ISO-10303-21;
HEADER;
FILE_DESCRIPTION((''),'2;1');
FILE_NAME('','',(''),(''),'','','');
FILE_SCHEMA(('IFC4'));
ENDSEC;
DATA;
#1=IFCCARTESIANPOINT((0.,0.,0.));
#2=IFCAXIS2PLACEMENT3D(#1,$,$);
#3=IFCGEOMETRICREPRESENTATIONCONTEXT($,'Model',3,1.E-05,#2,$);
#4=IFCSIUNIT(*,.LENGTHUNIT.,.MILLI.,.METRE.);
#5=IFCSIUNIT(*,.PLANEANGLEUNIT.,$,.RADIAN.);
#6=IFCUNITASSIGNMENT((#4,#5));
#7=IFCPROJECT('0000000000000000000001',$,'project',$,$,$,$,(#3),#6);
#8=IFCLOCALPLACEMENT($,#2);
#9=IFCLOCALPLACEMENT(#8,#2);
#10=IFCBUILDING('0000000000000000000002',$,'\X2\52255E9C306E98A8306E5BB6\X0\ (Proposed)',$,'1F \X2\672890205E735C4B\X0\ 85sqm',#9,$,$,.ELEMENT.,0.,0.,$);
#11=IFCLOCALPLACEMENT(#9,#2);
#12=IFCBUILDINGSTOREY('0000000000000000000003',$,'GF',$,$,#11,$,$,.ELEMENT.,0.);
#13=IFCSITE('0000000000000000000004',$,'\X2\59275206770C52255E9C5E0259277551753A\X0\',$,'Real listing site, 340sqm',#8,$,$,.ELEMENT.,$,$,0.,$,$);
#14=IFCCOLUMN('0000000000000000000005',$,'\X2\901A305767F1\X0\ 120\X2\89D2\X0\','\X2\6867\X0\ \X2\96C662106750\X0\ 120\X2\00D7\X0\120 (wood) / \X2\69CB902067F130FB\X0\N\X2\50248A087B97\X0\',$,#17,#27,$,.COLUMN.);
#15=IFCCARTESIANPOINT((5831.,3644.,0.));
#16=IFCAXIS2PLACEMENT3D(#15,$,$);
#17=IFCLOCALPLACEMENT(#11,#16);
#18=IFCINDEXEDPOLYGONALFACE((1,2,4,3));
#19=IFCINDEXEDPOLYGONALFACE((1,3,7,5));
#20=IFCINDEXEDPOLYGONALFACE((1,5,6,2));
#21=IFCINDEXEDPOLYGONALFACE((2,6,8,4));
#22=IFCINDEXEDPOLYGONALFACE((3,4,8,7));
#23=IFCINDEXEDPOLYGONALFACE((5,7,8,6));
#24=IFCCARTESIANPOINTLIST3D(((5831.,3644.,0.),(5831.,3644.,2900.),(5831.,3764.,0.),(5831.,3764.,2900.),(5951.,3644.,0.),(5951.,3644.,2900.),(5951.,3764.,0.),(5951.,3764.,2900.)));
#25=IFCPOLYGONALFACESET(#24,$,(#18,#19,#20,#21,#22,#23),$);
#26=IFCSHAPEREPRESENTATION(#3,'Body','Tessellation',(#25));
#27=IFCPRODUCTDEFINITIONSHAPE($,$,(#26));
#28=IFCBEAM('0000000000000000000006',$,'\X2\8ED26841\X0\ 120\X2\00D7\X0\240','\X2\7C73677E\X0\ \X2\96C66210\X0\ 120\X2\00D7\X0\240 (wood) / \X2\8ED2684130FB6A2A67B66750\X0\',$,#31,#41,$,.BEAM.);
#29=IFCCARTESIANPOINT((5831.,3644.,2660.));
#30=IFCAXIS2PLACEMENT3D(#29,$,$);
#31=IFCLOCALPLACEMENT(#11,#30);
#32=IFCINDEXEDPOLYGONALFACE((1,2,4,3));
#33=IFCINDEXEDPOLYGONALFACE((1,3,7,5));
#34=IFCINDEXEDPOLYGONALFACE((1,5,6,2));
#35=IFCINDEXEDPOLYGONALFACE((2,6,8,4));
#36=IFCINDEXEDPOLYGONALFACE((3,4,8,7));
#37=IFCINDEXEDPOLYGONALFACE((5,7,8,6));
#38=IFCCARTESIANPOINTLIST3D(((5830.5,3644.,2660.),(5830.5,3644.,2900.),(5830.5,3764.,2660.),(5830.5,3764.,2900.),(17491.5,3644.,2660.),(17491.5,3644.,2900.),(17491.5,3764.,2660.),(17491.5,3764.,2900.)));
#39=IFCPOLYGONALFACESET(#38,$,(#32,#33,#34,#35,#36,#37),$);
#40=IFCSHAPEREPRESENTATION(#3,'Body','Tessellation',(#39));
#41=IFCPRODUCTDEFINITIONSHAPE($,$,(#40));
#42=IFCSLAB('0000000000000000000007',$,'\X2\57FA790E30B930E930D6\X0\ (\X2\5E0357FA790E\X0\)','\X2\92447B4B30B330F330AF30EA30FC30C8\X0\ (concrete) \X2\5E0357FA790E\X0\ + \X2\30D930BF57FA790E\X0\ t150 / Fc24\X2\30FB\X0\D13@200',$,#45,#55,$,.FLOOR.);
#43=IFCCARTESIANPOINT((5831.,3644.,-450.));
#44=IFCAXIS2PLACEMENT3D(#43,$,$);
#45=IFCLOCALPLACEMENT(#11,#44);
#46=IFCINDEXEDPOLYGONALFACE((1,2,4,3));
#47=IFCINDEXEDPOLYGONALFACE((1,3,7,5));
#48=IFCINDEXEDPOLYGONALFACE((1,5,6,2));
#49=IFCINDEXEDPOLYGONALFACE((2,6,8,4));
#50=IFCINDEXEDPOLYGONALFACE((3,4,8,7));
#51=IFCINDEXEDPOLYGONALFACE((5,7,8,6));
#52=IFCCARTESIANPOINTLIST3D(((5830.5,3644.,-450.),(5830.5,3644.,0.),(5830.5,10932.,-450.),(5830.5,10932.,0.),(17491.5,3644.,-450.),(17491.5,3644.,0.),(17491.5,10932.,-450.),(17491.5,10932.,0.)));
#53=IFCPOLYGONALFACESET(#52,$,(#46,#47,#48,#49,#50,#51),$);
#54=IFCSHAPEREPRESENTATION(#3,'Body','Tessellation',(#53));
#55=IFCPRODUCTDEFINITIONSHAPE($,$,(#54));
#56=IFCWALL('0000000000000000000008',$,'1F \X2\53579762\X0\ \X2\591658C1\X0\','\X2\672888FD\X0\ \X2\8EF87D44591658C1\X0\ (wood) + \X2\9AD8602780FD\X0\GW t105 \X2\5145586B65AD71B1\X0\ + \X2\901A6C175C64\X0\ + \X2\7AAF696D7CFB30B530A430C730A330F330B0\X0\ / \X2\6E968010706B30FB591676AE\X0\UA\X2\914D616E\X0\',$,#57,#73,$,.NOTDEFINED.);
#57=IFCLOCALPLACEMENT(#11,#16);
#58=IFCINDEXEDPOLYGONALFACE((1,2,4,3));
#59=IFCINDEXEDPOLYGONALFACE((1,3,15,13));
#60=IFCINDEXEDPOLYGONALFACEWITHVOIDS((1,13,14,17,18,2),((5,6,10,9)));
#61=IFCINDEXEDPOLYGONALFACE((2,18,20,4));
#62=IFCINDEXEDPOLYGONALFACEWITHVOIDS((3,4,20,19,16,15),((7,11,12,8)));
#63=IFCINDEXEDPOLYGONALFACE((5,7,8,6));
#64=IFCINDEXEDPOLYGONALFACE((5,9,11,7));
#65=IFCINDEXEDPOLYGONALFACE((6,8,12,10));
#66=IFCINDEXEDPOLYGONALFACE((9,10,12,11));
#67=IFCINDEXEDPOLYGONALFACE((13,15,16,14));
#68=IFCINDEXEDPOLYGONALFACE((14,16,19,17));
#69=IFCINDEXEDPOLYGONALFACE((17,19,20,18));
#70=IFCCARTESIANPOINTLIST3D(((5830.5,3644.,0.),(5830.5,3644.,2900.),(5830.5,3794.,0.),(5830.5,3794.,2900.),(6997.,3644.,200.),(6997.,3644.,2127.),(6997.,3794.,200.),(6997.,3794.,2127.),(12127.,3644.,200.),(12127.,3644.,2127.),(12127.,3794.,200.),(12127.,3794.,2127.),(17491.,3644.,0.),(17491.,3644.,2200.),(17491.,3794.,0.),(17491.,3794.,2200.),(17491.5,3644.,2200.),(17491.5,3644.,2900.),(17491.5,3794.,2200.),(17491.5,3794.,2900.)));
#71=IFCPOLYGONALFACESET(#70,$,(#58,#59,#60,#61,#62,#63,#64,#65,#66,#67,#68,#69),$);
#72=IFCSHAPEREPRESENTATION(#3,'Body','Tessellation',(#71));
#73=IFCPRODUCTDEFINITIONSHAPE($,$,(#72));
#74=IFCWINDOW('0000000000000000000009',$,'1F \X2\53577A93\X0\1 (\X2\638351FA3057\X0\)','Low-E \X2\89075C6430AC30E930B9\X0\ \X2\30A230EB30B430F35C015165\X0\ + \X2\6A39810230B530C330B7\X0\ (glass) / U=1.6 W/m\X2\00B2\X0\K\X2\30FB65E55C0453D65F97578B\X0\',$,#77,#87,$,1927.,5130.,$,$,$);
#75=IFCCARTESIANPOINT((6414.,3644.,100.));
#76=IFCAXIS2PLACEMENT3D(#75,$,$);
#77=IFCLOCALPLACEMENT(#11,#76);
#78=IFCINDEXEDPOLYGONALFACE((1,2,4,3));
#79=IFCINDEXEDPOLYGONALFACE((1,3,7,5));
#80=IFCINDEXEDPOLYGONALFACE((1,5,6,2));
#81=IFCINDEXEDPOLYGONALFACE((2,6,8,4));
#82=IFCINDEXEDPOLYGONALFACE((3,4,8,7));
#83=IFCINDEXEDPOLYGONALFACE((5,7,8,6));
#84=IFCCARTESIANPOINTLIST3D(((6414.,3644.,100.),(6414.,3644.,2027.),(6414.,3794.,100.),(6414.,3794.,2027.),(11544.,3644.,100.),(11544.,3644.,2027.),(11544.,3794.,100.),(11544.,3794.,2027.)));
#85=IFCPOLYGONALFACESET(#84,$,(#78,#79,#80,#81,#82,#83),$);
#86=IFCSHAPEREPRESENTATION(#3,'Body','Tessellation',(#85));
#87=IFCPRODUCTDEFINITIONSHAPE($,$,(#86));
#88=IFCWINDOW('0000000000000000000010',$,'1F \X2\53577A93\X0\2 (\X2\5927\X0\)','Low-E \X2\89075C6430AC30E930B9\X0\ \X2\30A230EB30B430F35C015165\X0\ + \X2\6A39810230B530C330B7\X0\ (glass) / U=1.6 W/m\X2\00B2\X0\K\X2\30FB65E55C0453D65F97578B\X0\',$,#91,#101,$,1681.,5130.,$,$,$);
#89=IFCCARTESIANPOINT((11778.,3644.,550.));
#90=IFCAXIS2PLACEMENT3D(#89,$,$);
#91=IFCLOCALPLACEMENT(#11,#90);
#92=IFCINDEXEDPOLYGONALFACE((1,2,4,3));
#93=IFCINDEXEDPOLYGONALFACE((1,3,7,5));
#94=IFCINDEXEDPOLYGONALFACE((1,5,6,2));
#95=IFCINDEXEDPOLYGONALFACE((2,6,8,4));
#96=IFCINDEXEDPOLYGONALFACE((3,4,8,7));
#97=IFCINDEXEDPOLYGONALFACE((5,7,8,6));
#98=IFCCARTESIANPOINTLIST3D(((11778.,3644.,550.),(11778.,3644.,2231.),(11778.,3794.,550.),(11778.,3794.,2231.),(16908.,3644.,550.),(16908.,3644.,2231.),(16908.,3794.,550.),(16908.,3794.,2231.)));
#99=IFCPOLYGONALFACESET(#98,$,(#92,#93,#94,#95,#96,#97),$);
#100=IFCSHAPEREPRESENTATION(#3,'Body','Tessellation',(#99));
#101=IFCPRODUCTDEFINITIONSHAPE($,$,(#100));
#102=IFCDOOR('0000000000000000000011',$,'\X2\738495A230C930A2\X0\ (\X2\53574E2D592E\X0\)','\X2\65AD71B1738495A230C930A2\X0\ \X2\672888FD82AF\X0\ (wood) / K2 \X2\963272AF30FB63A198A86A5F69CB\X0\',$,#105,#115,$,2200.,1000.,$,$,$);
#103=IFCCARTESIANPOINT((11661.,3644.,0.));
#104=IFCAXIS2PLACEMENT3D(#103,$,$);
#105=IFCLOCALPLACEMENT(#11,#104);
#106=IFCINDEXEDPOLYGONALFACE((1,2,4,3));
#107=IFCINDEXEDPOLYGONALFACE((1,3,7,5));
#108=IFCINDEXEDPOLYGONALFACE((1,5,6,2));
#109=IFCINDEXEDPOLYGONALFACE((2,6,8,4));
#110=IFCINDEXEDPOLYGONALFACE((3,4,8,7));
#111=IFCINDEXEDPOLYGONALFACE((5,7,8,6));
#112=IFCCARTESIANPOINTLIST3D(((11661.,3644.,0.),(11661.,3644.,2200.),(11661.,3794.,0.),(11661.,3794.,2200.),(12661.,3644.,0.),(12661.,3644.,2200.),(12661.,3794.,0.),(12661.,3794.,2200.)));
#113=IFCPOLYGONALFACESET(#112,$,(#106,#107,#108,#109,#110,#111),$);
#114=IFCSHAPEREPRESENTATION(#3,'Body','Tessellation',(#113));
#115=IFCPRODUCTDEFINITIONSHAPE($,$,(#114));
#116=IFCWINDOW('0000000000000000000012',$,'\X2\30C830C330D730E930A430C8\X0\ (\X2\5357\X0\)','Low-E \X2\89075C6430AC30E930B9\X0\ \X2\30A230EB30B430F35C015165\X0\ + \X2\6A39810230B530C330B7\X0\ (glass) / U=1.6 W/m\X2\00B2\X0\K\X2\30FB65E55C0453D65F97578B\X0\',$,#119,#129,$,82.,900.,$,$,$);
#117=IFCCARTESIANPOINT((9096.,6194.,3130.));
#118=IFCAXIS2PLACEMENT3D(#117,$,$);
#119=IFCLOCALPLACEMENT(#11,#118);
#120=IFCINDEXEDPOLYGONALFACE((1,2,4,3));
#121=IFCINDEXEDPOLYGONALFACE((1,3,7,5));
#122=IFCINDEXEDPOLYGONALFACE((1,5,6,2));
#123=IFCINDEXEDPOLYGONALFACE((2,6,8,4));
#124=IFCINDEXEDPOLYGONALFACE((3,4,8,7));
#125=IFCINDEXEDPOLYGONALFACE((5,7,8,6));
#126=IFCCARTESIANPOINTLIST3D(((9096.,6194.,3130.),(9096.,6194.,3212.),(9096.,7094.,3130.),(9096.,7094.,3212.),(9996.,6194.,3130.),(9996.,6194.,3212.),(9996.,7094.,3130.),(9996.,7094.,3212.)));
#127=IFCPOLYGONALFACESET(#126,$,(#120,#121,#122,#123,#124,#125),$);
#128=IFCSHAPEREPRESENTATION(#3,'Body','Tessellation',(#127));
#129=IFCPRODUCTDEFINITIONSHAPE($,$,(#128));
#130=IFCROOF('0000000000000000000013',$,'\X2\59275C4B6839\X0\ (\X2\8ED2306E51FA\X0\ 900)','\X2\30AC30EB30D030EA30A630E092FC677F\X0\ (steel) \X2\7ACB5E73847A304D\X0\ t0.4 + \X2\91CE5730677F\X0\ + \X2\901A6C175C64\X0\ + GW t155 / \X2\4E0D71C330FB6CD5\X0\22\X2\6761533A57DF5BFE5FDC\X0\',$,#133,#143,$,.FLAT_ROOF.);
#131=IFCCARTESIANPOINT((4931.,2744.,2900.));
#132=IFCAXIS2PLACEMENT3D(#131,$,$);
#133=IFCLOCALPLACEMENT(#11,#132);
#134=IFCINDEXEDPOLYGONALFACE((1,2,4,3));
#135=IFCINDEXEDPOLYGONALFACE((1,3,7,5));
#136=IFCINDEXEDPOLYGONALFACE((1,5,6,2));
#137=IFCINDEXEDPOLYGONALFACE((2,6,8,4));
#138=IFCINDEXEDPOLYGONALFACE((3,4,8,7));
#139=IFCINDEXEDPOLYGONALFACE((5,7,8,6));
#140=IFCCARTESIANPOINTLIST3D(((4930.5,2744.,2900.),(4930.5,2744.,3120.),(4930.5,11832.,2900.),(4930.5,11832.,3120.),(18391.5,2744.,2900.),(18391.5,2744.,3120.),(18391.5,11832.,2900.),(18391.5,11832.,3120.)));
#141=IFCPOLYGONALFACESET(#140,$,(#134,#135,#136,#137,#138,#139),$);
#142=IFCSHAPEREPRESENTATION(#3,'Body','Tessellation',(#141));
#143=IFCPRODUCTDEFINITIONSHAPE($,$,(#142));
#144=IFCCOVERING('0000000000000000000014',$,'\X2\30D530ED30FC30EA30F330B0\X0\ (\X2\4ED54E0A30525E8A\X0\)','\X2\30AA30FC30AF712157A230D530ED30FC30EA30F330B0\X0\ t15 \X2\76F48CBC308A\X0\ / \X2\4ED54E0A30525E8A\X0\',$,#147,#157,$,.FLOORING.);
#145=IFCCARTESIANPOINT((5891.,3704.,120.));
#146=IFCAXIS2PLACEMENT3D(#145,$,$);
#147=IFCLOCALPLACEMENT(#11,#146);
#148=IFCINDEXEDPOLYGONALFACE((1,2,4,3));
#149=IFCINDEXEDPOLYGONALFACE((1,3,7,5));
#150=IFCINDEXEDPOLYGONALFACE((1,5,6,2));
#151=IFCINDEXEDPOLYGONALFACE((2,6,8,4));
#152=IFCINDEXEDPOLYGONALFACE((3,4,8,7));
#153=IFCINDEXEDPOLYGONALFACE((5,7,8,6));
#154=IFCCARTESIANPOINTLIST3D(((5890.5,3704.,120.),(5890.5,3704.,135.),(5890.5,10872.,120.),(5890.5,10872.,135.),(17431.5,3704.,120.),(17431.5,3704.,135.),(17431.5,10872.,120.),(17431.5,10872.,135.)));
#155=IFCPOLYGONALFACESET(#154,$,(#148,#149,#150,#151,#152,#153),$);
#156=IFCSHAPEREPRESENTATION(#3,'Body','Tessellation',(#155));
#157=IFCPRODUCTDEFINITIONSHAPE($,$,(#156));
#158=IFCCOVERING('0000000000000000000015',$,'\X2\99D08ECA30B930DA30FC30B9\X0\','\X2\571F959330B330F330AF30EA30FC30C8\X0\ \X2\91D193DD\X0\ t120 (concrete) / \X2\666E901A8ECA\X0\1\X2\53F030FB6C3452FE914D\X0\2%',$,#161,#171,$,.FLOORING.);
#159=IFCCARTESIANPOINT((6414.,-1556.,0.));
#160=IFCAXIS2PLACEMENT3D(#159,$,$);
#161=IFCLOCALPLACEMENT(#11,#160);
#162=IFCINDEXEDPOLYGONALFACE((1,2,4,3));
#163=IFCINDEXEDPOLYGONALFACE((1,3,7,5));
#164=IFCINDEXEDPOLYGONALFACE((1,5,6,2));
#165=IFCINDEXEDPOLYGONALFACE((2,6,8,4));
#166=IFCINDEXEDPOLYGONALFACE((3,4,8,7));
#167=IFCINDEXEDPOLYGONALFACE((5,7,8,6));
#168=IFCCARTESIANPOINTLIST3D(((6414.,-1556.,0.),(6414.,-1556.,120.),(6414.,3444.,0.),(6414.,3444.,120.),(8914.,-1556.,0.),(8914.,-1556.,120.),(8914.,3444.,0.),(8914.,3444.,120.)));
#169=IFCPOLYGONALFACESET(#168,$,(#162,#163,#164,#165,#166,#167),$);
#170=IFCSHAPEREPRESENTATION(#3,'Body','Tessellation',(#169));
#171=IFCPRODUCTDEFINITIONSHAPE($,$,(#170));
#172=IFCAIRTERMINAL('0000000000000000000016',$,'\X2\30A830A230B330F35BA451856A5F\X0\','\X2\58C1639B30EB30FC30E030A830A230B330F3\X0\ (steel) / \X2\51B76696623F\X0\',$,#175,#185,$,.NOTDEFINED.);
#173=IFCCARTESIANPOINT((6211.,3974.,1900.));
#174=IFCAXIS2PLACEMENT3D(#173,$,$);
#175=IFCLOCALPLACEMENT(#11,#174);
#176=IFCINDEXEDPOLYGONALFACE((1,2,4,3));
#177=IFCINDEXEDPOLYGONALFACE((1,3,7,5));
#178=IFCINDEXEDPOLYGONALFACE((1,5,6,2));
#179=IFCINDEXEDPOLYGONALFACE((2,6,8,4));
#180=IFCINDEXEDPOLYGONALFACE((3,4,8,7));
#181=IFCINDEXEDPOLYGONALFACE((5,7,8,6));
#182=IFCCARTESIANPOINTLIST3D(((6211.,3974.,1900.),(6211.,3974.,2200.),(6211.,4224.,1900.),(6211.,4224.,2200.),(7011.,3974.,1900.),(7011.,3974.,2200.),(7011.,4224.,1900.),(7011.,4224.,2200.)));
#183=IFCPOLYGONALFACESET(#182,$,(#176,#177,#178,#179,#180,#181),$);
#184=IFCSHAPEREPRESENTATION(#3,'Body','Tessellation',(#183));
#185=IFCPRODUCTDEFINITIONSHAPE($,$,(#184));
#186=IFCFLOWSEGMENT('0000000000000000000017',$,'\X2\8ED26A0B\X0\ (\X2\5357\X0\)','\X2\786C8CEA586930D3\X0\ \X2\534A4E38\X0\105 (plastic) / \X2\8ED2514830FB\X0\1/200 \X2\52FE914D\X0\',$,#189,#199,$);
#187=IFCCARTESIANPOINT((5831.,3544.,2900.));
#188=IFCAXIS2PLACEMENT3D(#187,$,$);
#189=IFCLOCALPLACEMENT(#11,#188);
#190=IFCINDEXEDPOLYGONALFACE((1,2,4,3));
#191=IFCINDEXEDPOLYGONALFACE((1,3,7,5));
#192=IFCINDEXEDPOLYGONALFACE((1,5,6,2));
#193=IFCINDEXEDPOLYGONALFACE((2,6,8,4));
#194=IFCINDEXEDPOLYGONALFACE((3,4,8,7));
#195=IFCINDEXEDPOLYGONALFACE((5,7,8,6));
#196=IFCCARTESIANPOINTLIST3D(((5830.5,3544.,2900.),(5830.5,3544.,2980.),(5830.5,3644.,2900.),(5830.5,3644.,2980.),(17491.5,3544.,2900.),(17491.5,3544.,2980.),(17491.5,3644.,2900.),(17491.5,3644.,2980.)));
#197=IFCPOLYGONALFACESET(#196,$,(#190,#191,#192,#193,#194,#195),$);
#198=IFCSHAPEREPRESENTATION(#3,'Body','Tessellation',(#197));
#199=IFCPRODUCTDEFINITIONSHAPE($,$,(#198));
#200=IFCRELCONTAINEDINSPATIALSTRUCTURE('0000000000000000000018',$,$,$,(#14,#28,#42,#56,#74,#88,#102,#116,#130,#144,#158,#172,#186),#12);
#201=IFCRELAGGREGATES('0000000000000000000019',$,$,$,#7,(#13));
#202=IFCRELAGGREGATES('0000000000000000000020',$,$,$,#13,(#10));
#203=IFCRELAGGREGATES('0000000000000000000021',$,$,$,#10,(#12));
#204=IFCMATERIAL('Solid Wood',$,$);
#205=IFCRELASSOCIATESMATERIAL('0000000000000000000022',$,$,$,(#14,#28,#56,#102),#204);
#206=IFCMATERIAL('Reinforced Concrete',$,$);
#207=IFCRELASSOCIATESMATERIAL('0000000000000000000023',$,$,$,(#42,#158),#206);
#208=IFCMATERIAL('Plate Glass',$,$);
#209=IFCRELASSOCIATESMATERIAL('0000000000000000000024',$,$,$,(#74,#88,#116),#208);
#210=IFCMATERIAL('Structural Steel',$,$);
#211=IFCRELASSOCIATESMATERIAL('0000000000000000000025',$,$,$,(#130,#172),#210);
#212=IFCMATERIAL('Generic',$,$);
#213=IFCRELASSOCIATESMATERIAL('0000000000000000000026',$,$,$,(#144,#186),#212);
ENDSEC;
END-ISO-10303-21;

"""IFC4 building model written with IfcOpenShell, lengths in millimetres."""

from ifc_helpers import new_model, si_unit, frame, frame_2d, origin, place, context, project, spatial, rectangle, extrude, material, element, fill, save


model = new_model("IFC4")

# Units and contexts
model_context = context("Model", 3, precision=1e-05, world=origin())
ifc_project = project(units=[si_unit("LENGTHUNIT", "METRE", prefix="MILLI"), si_unit("PLANEANGLEUNIT", "RADIAN")], contexts=[model_context])

# Site, building, storey
site_placement = place(None, origin())
site = spatial("IfcSite", under=ifc_project, at=site_placement, Name="大分県別府市大畑町", ObjectType="Real listing site, 340sqm", CompositionType="ELEMENT", RefElevation=0.0)
building_placement = place(site_placement, origin())
building = spatial("IfcBuilding", under=site, at=building_placement, Name="別府の風の家 (Proposed)", ObjectType="1F 木造平屋 85sqm", CompositionType="ELEMENT", ElevationOfRefHeight=0.0, ElevationOfTerrain=0.0)
storey_placement = place(building_placement, origin())
storey = spatial("IfcBuildingStorey", under=building, at=storey_placement, Name="GF", CompositionType="ELEMENT", Elevation=0.0)

# Column
ifc_material_1 = material(Name="Solid Wood")
column_1_placement = place(storey_placement, frame((5831.0, 3644.0, 0.0)))
element("IfcColumn", 1, at=column_1_placement, inside=storey, material=ifc_material_1, Name="通し柱 120角", Description="桧 集成材 120×120 (wood) / 構造柱・N値計算", PredefinedType="COLUMN", context=model_context, shape_type="SweptSolid", body=[
    extrude(rectangle(XDim=120.0, YDim=120.0, at=frame_2d((60.0, 60.0))), frame((5831.0, 3644.0, 0.0)), (0.0, 0.0, 1.0), 2900.0),
])

# Beam
beam_1_placement = place(storey_placement, frame((5831.0, 3644.0, 2660.0)))
element("IfcBeam", 2, at=beam_1_placement, inside=storey, material=ifc_material_1, Name="軒桁 120×240", Description="米松 集成 120×240 (wood) / 軒桁・横架材", PredefinedType="BEAM", context=model_context, shape_type="SweptSolid", body=[
    extrude(rectangle(XDim=11661.0, YDim=120.0, at=frame_2d((5830.0, 60.0))), frame((5831.0, 3644.0, 2660.0)), (0.0, 0.0, 1.0), 240.0),
])

# Slab
ifc_material_2 = material(Name="Reinforced Concrete")
slab_1_placement = place(storey_placement, frame((5831.0, 3644.0, -450.0)))
element("IfcSlab", 3, at=slab_1_placement, inside=storey, material=ifc_material_2, Name="基礎スラブ (布基礎)", Description="鉄筋コンクリート (concrete) 布基礎 + ベタ基礎 t150 / Fc24・D13@200", PredefinedType="FLOOR", context=model_context, shape_type="SweptSolid", body=[
    extrude(rectangle(XDim=11661.0, YDim=7288.0, at=frame_2d((5830.0, 3644.0))), frame((5831.0, 3644.0, -450.0)), (0.0, 0.0, 1.0), 450.0),
])

# Wall, openings, windows, door
wall_1_placement = place(storey_placement, frame((5831.0, 3644.0, 0.0)))
wall_1 = element("IfcWall", 4, at=wall_1_placement, inside=storey, material=ifc_material_1, Name="1F 南面 外壁", Description="木製 軸組外壁 (wood) + 高性能GW t105 充填断熱 + 通気層 + 窯業系サイディング / 準耐火・外皮UA配慮", PredefinedType="NOTDEFINED", context=model_context, shape_type="SweptSolid", body=[
    extrude(rectangle(XDim=11661.0, YDim=150.0, at=frame_2d((5830.0, 75.0))), frame((5831.0, 3644.0, 0.0)), (0.0, 0.0, 1.0), 2900.0),
])
opening_1_placement = place(storey_placement, frame((6414.0, 3644.0, 100.0)))
opening_1 = element("IfcOpeningElement", 5, at=opening_1_placement, cuts=wall_1, PredefinedType="NOTDEFINED", context=model_context, shape_type="SweptSolid", body=[
    extrude(rectangle(XDim=5130.0, YDim=150.0, at=frame_2d((2565.0, 75.0))), frame((6414.0, 3644.0, 100.0)), (0.0, 0.0, 1.0), 1927.0),
])
opening_2_placement = place(storey_placement, frame((11778.0, 3644.0, 550.0)))
opening_2 = element("IfcOpeningElement", 6, at=opening_2_placement, cuts=wall_1, PredefinedType="NOTDEFINED", context=model_context, shape_type="SweptSolid", body=[
    extrude(rectangle(XDim=5130.0, YDim=150.0, at=frame_2d((2565.0, 75.0))), frame((11778.0, 3644.0, 550.0)), (0.0, 0.0, 1.0), 1681.0),
])
opening_3_placement = place(storey_placement, frame((11661.0, 3644.0, 0.0)))
opening_3 = element("IfcOpeningElement", 7, at=opening_3_placement, cuts=wall_1, PredefinedType="NOTDEFINED", context=model_context, shape_type="SweptSolid", body=[
    extrude(rectangle(XDim=1000.0, YDim=150.0, at=frame_2d((500.0, 75.0))), frame((11661.0, 3644.0, 0.0)), (0.0, 0.0, 1.0), 2200.0),
])
ifc_material_3 = material(Name="Plate Glass")
window_1_placement = place(storey_placement, frame((6414.0, 3644.0, 100.0)))
window_1 = element("IfcWindow", 8, at=window_1_placement, inside=storey, material=ifc_material_3, Name="1F 南窓1 (掃出し)", Description="Low-E 複層ガラス アルゴン封入 + 樹脂サッシ (glass) / U=1.6 W/m²K・日射取得型", OverallHeight=1927.0, OverallWidth=5130.0, context=model_context, shape_type="SweptSolid", body=[
    extrude(rectangle(XDim=5130.0, YDim=150.0, at=frame_2d((2565.0, 75.0))), frame((6414.0, 3644.0, 100.0)), (0.0, 0.0, 1.0), 1927.0),
])
fill(opening_1, window_1)
window_2_placement = place(storey_placement, frame((11778.0, 3644.0, 550.0)))
window_2 = element("IfcWindow", 9, at=window_2_placement, inside=storey, material=ifc_material_3, Name="1F 南窓2 (大)", Description="Low-E 複層ガラス アルゴン封入 + 樹脂サッシ (glass) / U=1.6 W/m²K・日射取得型", OverallHeight=1681.0, OverallWidth=5130.0, context=model_context, shape_type="SweptSolid", body=[
    extrude(rectangle(XDim=5130.0, YDim=150.0, at=frame_2d((2565.0, 75.0))), frame((11778.0, 3644.0, 550.0)), (0.0, 0.0, 1.0), 1681.0),
])
fill(opening_2, window_2)
door_placement = place(storey_placement, frame((11661.0, 3644.0, 0.0)))
door = element("IfcDoor", 10, at=door_placement, inside=storey, material=ifc_material_1, Name="玄関ドア (南中央)", Description="断熱玄関ドア 木製芯 (wood) / K2 防犯・採風機構", OverallHeight=2200.0, OverallWidth=1000.0, context=model_context, shape_type="SweptSolid", body=[
    extrude(rectangle(XDim=1000.0, YDim=150.0, at=frame_2d((500.0, 75.0))), frame((11661.0, 3644.0, 0.0)), (0.0, 0.0, 1.0), 2200.0),
])
fill(opening_3, door)

# Window
window_3_placement = place(storey_placement, frame((9096.0, 6194.0, 3130.0)))
element("IfcWindow", 11, at=window_3_placement, inside=storey, material=ifc_material_3, Name="トップライト (南)", Description="Low-E 複層ガラス アルゴン封入 + 樹脂サッシ (glass) / U=1.6 W/m²K・日射取得型", OverallHeight=82.0, OverallWidth=900.0, context=model_context, shape_type="SweptSolid", body=[
    extrude(rectangle(XDim=900.0, YDim=900.0, at=frame_2d((450.0, 450.0))), frame((9096.0, 6194.0, 3130.0)), (0.0, 0.0, 1.0), 82.0),
])

# Roof
ifc_material_4 = material(Name="Structural Steel")
roof_placement = place(storey_placement, frame((4931.0, 2744.0, 2900.0)))
element("IfcRoof", 12, at=roof_placement, inside=storey, material=ifc_material_4, Name="大屋根 (軒の出 900)", Description="ガルバリウム鋼板 (steel) 立平葺き t0.4 + 野地板 + 通気層 + GW t155 / 不燃・法22条区域対応", PredefinedType="FLAT_ROOF", context=model_context, shape_type="SweptSolid", body=[
    extrude(rectangle(XDim=13461.0, YDim=9088.0, at=frame_2d((6730.0, 4544.0))), frame((4931.0, 2744.0, 2900.0)), (0.0, 0.0, 1.0), 220.0),
])

# Coverings
ifc_material_5 = material(Name="Generic")
covering_1_placement = place(storey_placement, frame((5891.0, 3704.0, 120.0)))
element("IfcCovering", 13, at=covering_1_placement, inside=storey, material=ifc_material_5, Name="フローリング (仕上げ床)", Description="オーク無垢フローリング t15 直貼り / 仕上げ床", PredefinedType="FLOORING", context=model_context, shape_type="SweptSolid", body=[
    extrude(rectangle(XDim=11541.0, YDim=7168.0, at=frame_2d((5770.0, 3584.0))), frame((5891.0, 3704.0, 120.0)), (0.0, 0.0, 1.0), 15.0),
])
covering_2_placement = place(storey_placement, frame((6414.0, -1556.0, 0.0)))
element("IfcCovering", 14, at=covering_2_placement, inside=storey, material=ifc_material_2, Name="駐車スペース", Description="土間コンクリート 金鏝 t120 (concrete) / 普通車1台・水勾配2%", PredefinedType="FLOORING", context=model_context, shape_type="SweptSolid", body=[
    extrude(rectangle(XDim=2500.0, YDim=5000.0, at=frame_2d((1250.0, 2500.0))), frame((6414.0, -1556.0, 0.0)), (0.0, 0.0, 1.0), 120.0),
])

# Air terminal
air_terminal_placement = place(storey_placement, frame((6211.0, 3974.0, 1900.0)))
element("IfcAirTerminal", 15, at=air_terminal_placement, inside=storey, material=ifc_material_4, Name="エアコン室内機", Description="壁掛ルームエアコン (steel) / 冷暖房", PredefinedType="NOTDEFINED", context=model_context, shape_type="SweptSolid", body=[
    extrude(rectangle(XDim=800.0, YDim=250.0, at=frame_2d((400.0, 125.0))), frame((6211.0, 3974.0, 1900.0)), (0.0, 0.0, 1.0), 300.0),
])

# Flow segment
flow_segment_1_placement = place(storey_placement, frame((5831.0, 3544.0, 2900.0)))
element("IfcFlowSegment", 16, at=flow_segment_1_placement, inside=storey, material=ifc_material_5, Name="軒樋 (南)", Description="硬質塩ビ 半丸105 (plastic) / 軒先・1/200 勾配", context=model_context, shape_type="SweptSolid", body=[
    extrude(rectangle(XDim=11661.0, YDim=100.0, at=frame_2d((5830.0, 50.0))), frame((5831.0, 3544.0, 2900.0)), (0.0, 0.0, 1.0), 80.0),
])

save(model, "model.ifc")
